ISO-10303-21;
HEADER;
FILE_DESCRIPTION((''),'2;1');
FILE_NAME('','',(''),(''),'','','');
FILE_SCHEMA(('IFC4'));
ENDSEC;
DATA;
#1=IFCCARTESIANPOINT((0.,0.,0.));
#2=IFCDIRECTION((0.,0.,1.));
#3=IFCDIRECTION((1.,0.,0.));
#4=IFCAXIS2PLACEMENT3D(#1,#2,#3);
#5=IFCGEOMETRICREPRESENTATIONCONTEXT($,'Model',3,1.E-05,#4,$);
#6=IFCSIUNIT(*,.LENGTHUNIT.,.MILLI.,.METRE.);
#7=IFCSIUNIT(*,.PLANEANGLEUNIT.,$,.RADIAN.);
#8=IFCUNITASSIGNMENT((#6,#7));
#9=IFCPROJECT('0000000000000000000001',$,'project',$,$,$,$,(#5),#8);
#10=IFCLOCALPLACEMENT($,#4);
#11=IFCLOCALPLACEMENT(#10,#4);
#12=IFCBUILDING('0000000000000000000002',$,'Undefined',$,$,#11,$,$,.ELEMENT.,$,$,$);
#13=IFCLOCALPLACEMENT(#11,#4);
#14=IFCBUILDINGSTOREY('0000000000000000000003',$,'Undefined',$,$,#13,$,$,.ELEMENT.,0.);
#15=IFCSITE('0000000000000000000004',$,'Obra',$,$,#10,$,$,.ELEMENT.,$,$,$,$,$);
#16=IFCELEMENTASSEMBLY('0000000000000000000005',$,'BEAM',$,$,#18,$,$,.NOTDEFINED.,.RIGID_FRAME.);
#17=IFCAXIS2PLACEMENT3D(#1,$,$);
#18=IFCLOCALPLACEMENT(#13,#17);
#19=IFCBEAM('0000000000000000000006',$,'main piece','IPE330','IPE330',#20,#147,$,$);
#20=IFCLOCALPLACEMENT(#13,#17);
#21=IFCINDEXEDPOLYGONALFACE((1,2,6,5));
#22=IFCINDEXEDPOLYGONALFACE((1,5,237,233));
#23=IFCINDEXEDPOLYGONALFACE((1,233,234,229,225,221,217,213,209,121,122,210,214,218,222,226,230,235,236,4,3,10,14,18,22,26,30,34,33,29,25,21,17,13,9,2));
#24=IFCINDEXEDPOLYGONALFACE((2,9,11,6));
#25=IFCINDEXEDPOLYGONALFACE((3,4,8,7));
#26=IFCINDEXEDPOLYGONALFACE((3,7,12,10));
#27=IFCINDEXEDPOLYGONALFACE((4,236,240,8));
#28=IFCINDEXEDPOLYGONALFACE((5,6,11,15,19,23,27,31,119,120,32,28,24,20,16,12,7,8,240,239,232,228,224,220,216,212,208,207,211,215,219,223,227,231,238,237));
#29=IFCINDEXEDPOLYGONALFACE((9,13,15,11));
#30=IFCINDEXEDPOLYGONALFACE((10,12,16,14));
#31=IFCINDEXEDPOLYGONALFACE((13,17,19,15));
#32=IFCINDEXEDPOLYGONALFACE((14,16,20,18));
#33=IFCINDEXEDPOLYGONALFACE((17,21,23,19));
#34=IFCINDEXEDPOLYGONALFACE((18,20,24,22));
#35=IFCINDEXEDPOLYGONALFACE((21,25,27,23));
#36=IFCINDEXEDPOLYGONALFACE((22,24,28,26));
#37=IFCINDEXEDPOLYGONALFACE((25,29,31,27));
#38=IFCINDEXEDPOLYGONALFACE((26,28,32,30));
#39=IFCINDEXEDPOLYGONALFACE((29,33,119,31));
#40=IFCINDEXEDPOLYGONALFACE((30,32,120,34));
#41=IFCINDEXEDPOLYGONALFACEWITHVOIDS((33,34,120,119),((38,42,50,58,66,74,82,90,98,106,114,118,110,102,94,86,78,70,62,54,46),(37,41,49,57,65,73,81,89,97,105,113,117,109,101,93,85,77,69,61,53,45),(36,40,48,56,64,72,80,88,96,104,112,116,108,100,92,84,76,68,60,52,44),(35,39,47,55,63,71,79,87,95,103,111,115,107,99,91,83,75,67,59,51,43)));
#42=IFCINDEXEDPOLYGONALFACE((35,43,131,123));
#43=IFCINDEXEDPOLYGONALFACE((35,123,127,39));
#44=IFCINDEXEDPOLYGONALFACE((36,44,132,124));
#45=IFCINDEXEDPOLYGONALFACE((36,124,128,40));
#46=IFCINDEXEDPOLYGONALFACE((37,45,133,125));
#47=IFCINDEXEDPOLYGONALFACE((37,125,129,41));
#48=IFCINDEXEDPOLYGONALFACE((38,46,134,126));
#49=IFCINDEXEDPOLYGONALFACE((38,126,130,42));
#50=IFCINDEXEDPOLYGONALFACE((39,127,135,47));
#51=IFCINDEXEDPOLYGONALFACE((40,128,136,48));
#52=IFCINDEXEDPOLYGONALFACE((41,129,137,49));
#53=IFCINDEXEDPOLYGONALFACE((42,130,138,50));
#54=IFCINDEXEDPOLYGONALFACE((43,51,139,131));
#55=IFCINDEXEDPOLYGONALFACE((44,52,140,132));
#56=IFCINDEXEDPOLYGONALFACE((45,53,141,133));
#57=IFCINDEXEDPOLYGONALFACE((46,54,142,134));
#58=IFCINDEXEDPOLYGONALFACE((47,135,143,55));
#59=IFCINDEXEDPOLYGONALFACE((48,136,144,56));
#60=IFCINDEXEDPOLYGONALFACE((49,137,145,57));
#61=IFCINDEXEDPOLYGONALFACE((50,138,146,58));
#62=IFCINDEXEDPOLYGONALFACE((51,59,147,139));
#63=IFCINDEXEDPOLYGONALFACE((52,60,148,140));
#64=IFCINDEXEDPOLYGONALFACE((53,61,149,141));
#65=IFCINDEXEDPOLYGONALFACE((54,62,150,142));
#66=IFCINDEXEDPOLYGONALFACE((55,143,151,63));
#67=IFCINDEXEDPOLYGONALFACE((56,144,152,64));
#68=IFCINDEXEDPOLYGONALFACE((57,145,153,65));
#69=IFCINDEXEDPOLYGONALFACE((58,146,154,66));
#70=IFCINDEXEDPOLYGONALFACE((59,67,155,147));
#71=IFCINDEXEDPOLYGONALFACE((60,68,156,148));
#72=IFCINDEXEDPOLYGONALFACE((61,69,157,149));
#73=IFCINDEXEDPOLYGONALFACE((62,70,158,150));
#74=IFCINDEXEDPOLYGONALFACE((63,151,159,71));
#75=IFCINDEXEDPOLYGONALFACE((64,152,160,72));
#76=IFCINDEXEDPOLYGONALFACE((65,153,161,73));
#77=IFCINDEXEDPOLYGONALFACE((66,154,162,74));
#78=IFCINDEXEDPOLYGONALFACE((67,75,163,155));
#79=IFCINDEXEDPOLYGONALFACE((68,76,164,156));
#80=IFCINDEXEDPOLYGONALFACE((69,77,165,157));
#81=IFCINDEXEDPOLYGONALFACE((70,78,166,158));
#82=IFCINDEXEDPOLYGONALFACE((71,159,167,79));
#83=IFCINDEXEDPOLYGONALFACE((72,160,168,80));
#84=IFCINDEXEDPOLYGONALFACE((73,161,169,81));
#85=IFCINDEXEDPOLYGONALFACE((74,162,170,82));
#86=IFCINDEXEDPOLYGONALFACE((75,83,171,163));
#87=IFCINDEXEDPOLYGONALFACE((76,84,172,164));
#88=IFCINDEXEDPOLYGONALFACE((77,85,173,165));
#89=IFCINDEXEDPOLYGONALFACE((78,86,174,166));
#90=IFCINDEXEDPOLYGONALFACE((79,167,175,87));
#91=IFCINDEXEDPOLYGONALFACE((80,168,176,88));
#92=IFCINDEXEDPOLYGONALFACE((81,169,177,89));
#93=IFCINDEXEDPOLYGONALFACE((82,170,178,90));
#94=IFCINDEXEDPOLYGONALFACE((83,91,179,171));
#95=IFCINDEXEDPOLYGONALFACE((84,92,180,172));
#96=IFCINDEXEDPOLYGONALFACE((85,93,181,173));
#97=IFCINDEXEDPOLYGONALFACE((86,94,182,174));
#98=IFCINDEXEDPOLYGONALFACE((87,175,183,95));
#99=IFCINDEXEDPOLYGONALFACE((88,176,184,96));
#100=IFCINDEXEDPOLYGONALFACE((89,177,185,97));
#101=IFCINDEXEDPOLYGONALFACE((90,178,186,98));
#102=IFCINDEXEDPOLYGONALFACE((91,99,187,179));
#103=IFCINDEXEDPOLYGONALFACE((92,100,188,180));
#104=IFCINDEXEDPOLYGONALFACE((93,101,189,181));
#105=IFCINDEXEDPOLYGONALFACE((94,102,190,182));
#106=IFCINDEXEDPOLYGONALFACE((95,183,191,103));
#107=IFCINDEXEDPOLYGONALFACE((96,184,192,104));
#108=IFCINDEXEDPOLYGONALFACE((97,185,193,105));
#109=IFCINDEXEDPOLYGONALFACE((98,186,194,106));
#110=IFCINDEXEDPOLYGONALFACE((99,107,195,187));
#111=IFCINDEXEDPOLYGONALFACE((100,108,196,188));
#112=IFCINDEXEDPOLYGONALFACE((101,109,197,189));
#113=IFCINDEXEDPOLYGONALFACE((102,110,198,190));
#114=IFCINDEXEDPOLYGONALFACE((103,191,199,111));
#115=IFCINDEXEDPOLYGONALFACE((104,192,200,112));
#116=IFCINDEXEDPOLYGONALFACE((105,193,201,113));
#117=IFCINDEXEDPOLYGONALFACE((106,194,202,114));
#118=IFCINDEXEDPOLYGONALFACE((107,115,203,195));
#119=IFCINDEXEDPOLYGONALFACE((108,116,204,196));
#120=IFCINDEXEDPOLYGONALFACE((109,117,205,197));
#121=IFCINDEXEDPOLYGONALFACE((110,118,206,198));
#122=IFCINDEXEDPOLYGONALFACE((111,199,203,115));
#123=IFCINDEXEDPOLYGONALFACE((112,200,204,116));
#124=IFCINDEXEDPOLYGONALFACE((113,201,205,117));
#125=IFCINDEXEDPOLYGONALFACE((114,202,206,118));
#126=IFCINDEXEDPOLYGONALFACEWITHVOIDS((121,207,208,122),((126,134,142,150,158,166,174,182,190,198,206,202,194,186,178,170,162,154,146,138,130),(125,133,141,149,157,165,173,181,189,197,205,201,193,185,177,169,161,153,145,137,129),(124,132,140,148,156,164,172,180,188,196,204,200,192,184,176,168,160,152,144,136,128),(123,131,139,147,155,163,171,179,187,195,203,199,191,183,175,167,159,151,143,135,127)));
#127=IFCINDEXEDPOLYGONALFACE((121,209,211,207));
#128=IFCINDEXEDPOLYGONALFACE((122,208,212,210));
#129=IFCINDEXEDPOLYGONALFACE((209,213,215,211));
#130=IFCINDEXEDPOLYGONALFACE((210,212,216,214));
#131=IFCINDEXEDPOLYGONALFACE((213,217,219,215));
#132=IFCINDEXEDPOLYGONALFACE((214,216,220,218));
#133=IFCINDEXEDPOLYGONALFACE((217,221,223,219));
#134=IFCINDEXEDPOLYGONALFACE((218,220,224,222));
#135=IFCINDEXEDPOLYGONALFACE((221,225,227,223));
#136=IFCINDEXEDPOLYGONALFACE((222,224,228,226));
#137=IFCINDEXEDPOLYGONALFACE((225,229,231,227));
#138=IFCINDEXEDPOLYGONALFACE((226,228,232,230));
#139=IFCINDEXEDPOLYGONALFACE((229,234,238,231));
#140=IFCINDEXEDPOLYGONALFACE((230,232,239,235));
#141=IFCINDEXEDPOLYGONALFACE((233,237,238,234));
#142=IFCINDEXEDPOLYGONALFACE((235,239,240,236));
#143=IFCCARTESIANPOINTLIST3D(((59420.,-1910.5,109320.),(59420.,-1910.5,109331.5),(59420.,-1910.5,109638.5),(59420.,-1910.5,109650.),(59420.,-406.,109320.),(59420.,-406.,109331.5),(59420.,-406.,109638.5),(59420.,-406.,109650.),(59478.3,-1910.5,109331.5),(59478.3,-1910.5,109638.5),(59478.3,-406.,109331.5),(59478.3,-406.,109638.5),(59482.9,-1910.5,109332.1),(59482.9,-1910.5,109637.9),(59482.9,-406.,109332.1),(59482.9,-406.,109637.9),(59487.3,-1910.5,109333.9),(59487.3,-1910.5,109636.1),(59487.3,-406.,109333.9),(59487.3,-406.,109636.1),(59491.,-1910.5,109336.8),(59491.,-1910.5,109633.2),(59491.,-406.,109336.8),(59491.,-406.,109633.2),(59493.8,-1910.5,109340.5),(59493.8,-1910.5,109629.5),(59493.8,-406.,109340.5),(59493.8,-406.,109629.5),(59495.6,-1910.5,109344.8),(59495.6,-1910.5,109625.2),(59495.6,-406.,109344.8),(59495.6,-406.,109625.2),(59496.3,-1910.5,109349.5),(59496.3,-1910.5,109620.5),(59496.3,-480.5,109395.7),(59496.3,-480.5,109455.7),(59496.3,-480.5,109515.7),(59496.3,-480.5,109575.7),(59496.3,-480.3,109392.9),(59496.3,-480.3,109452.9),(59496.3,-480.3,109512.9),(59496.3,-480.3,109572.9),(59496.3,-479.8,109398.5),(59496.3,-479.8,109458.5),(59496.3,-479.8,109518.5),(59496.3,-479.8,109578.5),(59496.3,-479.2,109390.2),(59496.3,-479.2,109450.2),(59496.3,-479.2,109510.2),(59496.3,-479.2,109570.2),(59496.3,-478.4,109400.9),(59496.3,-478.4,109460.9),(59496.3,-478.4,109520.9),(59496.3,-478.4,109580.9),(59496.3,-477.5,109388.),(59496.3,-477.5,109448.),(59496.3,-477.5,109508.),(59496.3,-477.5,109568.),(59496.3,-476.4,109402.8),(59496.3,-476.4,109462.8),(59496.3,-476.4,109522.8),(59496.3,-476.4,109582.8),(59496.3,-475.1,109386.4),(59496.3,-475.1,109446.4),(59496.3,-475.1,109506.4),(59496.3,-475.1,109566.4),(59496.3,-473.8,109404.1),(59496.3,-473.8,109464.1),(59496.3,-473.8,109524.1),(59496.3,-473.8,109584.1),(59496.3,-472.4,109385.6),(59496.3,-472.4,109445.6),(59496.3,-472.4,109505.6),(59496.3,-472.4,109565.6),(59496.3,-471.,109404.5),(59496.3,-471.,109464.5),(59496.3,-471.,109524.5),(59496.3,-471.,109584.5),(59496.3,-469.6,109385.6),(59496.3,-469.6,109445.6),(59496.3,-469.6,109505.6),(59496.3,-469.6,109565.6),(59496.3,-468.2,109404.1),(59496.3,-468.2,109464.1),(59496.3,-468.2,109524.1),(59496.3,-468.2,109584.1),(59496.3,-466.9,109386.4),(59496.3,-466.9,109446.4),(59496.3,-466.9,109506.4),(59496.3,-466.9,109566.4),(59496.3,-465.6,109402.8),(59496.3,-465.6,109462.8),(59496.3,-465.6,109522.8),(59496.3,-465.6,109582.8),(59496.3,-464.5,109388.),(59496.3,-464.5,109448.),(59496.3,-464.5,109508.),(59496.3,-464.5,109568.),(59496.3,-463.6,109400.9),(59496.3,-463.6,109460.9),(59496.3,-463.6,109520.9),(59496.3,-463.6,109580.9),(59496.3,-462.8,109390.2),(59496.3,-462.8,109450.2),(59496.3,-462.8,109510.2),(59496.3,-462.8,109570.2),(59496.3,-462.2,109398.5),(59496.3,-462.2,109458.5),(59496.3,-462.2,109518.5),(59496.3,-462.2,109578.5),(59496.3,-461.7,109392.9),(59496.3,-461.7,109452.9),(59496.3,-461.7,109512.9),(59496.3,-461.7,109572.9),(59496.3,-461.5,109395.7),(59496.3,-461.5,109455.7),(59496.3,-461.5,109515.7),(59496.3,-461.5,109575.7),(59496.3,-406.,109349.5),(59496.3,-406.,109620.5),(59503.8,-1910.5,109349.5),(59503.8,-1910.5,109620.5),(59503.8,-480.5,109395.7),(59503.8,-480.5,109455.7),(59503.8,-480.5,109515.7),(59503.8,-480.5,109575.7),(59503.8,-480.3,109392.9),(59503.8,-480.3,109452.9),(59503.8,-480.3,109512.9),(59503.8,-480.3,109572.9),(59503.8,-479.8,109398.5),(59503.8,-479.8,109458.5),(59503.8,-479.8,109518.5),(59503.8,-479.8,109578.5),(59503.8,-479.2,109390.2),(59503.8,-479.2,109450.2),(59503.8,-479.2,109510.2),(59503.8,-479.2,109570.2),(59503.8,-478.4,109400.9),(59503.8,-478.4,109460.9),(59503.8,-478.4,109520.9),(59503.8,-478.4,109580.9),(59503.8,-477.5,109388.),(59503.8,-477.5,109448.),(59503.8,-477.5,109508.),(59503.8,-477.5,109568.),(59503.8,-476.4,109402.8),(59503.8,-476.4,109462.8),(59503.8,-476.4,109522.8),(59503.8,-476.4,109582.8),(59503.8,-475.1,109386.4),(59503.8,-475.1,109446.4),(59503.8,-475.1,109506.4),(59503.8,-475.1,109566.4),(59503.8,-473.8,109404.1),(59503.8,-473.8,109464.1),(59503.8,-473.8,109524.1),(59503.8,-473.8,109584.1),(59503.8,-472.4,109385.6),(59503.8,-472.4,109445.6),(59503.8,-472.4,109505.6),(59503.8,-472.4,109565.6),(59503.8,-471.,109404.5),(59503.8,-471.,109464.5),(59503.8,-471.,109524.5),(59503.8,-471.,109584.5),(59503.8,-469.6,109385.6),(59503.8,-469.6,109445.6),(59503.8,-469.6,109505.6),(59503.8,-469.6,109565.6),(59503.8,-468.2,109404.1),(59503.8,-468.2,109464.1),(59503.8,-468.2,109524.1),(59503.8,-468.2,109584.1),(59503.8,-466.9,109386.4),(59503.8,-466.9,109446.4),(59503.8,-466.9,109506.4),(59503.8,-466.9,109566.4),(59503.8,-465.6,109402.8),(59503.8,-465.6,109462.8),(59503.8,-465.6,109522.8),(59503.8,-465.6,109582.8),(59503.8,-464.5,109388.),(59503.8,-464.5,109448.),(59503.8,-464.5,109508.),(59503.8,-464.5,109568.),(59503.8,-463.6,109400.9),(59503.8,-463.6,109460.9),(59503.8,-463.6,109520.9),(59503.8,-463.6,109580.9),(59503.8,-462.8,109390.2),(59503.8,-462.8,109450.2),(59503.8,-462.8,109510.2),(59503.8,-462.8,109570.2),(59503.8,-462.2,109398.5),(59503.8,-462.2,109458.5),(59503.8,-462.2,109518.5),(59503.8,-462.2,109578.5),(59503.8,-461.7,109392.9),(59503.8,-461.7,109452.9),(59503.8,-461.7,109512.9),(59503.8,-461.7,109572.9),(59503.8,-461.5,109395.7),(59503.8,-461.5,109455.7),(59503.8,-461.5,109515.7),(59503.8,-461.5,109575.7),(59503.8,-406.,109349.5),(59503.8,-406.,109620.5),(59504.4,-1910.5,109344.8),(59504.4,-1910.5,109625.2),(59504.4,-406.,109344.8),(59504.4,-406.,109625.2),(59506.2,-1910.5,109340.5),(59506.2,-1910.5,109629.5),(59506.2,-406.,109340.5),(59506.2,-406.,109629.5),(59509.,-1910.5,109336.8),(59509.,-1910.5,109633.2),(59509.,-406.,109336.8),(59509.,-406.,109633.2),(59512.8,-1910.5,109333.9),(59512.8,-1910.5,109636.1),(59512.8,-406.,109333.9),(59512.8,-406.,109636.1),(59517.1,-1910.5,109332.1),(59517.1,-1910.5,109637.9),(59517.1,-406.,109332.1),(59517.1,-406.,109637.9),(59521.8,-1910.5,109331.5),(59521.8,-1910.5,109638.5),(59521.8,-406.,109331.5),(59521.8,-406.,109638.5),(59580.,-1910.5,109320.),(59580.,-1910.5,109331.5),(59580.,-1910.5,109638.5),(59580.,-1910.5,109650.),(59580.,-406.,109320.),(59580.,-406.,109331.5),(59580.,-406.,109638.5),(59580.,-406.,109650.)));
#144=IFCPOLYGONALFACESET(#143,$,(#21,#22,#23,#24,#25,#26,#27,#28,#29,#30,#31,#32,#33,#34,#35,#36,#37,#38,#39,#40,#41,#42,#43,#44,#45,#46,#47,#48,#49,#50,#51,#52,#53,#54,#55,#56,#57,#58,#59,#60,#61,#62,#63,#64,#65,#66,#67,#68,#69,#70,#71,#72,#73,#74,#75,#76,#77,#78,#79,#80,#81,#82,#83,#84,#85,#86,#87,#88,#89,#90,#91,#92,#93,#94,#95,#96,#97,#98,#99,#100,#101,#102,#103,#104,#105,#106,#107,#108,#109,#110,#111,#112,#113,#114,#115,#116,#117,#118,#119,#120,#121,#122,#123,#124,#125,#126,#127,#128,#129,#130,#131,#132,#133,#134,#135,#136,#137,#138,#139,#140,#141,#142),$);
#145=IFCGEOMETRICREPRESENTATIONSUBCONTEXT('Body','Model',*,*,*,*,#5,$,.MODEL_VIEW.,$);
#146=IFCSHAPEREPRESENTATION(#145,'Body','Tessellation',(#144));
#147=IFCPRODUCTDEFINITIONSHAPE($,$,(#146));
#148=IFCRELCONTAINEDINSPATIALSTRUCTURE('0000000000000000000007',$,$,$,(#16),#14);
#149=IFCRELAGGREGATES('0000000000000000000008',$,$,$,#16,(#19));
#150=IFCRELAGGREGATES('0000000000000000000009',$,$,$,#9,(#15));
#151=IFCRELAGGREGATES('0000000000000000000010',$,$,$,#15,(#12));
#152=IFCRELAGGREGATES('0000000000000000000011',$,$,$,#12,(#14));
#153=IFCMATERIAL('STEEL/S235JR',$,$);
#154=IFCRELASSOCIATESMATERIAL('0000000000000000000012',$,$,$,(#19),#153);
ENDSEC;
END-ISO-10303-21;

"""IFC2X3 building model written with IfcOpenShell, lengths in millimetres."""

from ifc_helpers import new_model, si_unit, frame, origin_with_axes, origin_2d_with_axis, place, context, subcontext, project, spatial, circle, i_section, extrude, clip, halfspace, source, transform, mapped, material, element, aggregate, save


model = new_model("IFC2X3")

# Units and contexts
model_context = context("Model", 3, precision=1e-05, world=origin_with_axes())
body_context = subcontext(model_context, "Body", "Model", "MODEL_VIEW")
ifc_project = project(units=[si_unit("LENGTHUNIT", "METRE", prefix="MILLI"), si_unit("PLANEANGLEUNIT", "RADIAN")], contexts=[model_context])

# Site, building, storey
site_placement = place(None, origin_with_axes())
site = spatial("IfcSite", under=ifc_project, at=site_placement, Name="Obra", CompositionType="ELEMENT")
building_placement = place(site_placement, origin_with_axes())
building = spatial("IfcBuilding", under=site, at=building_placement, Name="Undefined", CompositionType="ELEMENT")
storey_placement = place(building_placement, origin_with_axes())
storey = spatial("IfcBuildingStorey", under=building, at=storey_placement, Name="Undefined", CompositionType="ELEMENT", Elevation=0.0)

# Element assembly, beam, opening
assembly_1_placement = place(storey_placement, origin_with_axes())
assembly_1 = element("IfcElementAssembly", 1, at=assembly_1_placement, inside=storey, Name="BEAM", AssemblyPlace="NOTDEFINED", PredefinedType="RIGID_FRAME")
ifc_material_1 = material(Name="STEEL/S235JR")
beam_1_placement = place(assembly_1_placement, frame((59500.0, -1910.5, 109485.0), z_axis=(0.0, 0.0, 1.0), x_axis=(0.0, 1.0, 0.0)))
beam_1 = element("IfcBeam", 2, at=beam_1_placement, material=ifc_material_1, Name="main piece", Description="IPE330", ObjectType="IPE330", context=body_context, shape_type="Clipping", body=[
    clip(extrude(i_section(OverallWidth=160.0, OverallDepth=330.0, WebThickness=7.5, FlangeThickness=11.5, FilletRadius=18.0, at=origin_2d_with_axis()), frame((1504.5, 0.0, 0.0), z_axis=(-1.0, 0.0, 0.0), x_axis=(0.0, -1.0, 0.0)), (0.0, 0.0, 1.0), 1504.5), halfspace(frame((1504.5, 0.0, -220.0), z_axis=(-1.0, 0.0, 0.0), x_axis=(0.0, 1.0, 0.0)), True)),
])
shared_shape_1 = source(origin_with_axes(), body_context, "Body", "SweptSolid", [
    extrude(circle(Radius=9.5, at=origin_2d_with_axis()), frame((0.0, -3.9, 0.0), z_axis=(0.0, 1.0, 0.0), x_axis=(1.0, 0.0, 0.0)), (0.0, 0.0, 1.0), 7.7),
])
opening_1_placement = place(assembly_1_placement, frame((59500.0, -471.0, 109395.0), z_axis=(0.0, 1.0, 0.0), x_axis=(0.0, 0.0, 1.0)))
element("IfcOpeningElement", 3, at=opening_1_placement, cuts=beam_1, ObjectType="Opening", context=body_context, shape_type="MappedRepresentation", body=[
    mapped(shared_shape_1, transform((0.0, 0.0, 0.0))),
    mapped(shared_shape_1, transform((60.0, 0.0, 0.0))),
    mapped(shared_shape_1, transform((120.0, 0.0, 0.0))),
    mapped(shared_shape_1, transform((180.0, 0.0, 0.0))),
])
aggregate(assembly_1, [beam_1])

save(model, "model.ifc")
